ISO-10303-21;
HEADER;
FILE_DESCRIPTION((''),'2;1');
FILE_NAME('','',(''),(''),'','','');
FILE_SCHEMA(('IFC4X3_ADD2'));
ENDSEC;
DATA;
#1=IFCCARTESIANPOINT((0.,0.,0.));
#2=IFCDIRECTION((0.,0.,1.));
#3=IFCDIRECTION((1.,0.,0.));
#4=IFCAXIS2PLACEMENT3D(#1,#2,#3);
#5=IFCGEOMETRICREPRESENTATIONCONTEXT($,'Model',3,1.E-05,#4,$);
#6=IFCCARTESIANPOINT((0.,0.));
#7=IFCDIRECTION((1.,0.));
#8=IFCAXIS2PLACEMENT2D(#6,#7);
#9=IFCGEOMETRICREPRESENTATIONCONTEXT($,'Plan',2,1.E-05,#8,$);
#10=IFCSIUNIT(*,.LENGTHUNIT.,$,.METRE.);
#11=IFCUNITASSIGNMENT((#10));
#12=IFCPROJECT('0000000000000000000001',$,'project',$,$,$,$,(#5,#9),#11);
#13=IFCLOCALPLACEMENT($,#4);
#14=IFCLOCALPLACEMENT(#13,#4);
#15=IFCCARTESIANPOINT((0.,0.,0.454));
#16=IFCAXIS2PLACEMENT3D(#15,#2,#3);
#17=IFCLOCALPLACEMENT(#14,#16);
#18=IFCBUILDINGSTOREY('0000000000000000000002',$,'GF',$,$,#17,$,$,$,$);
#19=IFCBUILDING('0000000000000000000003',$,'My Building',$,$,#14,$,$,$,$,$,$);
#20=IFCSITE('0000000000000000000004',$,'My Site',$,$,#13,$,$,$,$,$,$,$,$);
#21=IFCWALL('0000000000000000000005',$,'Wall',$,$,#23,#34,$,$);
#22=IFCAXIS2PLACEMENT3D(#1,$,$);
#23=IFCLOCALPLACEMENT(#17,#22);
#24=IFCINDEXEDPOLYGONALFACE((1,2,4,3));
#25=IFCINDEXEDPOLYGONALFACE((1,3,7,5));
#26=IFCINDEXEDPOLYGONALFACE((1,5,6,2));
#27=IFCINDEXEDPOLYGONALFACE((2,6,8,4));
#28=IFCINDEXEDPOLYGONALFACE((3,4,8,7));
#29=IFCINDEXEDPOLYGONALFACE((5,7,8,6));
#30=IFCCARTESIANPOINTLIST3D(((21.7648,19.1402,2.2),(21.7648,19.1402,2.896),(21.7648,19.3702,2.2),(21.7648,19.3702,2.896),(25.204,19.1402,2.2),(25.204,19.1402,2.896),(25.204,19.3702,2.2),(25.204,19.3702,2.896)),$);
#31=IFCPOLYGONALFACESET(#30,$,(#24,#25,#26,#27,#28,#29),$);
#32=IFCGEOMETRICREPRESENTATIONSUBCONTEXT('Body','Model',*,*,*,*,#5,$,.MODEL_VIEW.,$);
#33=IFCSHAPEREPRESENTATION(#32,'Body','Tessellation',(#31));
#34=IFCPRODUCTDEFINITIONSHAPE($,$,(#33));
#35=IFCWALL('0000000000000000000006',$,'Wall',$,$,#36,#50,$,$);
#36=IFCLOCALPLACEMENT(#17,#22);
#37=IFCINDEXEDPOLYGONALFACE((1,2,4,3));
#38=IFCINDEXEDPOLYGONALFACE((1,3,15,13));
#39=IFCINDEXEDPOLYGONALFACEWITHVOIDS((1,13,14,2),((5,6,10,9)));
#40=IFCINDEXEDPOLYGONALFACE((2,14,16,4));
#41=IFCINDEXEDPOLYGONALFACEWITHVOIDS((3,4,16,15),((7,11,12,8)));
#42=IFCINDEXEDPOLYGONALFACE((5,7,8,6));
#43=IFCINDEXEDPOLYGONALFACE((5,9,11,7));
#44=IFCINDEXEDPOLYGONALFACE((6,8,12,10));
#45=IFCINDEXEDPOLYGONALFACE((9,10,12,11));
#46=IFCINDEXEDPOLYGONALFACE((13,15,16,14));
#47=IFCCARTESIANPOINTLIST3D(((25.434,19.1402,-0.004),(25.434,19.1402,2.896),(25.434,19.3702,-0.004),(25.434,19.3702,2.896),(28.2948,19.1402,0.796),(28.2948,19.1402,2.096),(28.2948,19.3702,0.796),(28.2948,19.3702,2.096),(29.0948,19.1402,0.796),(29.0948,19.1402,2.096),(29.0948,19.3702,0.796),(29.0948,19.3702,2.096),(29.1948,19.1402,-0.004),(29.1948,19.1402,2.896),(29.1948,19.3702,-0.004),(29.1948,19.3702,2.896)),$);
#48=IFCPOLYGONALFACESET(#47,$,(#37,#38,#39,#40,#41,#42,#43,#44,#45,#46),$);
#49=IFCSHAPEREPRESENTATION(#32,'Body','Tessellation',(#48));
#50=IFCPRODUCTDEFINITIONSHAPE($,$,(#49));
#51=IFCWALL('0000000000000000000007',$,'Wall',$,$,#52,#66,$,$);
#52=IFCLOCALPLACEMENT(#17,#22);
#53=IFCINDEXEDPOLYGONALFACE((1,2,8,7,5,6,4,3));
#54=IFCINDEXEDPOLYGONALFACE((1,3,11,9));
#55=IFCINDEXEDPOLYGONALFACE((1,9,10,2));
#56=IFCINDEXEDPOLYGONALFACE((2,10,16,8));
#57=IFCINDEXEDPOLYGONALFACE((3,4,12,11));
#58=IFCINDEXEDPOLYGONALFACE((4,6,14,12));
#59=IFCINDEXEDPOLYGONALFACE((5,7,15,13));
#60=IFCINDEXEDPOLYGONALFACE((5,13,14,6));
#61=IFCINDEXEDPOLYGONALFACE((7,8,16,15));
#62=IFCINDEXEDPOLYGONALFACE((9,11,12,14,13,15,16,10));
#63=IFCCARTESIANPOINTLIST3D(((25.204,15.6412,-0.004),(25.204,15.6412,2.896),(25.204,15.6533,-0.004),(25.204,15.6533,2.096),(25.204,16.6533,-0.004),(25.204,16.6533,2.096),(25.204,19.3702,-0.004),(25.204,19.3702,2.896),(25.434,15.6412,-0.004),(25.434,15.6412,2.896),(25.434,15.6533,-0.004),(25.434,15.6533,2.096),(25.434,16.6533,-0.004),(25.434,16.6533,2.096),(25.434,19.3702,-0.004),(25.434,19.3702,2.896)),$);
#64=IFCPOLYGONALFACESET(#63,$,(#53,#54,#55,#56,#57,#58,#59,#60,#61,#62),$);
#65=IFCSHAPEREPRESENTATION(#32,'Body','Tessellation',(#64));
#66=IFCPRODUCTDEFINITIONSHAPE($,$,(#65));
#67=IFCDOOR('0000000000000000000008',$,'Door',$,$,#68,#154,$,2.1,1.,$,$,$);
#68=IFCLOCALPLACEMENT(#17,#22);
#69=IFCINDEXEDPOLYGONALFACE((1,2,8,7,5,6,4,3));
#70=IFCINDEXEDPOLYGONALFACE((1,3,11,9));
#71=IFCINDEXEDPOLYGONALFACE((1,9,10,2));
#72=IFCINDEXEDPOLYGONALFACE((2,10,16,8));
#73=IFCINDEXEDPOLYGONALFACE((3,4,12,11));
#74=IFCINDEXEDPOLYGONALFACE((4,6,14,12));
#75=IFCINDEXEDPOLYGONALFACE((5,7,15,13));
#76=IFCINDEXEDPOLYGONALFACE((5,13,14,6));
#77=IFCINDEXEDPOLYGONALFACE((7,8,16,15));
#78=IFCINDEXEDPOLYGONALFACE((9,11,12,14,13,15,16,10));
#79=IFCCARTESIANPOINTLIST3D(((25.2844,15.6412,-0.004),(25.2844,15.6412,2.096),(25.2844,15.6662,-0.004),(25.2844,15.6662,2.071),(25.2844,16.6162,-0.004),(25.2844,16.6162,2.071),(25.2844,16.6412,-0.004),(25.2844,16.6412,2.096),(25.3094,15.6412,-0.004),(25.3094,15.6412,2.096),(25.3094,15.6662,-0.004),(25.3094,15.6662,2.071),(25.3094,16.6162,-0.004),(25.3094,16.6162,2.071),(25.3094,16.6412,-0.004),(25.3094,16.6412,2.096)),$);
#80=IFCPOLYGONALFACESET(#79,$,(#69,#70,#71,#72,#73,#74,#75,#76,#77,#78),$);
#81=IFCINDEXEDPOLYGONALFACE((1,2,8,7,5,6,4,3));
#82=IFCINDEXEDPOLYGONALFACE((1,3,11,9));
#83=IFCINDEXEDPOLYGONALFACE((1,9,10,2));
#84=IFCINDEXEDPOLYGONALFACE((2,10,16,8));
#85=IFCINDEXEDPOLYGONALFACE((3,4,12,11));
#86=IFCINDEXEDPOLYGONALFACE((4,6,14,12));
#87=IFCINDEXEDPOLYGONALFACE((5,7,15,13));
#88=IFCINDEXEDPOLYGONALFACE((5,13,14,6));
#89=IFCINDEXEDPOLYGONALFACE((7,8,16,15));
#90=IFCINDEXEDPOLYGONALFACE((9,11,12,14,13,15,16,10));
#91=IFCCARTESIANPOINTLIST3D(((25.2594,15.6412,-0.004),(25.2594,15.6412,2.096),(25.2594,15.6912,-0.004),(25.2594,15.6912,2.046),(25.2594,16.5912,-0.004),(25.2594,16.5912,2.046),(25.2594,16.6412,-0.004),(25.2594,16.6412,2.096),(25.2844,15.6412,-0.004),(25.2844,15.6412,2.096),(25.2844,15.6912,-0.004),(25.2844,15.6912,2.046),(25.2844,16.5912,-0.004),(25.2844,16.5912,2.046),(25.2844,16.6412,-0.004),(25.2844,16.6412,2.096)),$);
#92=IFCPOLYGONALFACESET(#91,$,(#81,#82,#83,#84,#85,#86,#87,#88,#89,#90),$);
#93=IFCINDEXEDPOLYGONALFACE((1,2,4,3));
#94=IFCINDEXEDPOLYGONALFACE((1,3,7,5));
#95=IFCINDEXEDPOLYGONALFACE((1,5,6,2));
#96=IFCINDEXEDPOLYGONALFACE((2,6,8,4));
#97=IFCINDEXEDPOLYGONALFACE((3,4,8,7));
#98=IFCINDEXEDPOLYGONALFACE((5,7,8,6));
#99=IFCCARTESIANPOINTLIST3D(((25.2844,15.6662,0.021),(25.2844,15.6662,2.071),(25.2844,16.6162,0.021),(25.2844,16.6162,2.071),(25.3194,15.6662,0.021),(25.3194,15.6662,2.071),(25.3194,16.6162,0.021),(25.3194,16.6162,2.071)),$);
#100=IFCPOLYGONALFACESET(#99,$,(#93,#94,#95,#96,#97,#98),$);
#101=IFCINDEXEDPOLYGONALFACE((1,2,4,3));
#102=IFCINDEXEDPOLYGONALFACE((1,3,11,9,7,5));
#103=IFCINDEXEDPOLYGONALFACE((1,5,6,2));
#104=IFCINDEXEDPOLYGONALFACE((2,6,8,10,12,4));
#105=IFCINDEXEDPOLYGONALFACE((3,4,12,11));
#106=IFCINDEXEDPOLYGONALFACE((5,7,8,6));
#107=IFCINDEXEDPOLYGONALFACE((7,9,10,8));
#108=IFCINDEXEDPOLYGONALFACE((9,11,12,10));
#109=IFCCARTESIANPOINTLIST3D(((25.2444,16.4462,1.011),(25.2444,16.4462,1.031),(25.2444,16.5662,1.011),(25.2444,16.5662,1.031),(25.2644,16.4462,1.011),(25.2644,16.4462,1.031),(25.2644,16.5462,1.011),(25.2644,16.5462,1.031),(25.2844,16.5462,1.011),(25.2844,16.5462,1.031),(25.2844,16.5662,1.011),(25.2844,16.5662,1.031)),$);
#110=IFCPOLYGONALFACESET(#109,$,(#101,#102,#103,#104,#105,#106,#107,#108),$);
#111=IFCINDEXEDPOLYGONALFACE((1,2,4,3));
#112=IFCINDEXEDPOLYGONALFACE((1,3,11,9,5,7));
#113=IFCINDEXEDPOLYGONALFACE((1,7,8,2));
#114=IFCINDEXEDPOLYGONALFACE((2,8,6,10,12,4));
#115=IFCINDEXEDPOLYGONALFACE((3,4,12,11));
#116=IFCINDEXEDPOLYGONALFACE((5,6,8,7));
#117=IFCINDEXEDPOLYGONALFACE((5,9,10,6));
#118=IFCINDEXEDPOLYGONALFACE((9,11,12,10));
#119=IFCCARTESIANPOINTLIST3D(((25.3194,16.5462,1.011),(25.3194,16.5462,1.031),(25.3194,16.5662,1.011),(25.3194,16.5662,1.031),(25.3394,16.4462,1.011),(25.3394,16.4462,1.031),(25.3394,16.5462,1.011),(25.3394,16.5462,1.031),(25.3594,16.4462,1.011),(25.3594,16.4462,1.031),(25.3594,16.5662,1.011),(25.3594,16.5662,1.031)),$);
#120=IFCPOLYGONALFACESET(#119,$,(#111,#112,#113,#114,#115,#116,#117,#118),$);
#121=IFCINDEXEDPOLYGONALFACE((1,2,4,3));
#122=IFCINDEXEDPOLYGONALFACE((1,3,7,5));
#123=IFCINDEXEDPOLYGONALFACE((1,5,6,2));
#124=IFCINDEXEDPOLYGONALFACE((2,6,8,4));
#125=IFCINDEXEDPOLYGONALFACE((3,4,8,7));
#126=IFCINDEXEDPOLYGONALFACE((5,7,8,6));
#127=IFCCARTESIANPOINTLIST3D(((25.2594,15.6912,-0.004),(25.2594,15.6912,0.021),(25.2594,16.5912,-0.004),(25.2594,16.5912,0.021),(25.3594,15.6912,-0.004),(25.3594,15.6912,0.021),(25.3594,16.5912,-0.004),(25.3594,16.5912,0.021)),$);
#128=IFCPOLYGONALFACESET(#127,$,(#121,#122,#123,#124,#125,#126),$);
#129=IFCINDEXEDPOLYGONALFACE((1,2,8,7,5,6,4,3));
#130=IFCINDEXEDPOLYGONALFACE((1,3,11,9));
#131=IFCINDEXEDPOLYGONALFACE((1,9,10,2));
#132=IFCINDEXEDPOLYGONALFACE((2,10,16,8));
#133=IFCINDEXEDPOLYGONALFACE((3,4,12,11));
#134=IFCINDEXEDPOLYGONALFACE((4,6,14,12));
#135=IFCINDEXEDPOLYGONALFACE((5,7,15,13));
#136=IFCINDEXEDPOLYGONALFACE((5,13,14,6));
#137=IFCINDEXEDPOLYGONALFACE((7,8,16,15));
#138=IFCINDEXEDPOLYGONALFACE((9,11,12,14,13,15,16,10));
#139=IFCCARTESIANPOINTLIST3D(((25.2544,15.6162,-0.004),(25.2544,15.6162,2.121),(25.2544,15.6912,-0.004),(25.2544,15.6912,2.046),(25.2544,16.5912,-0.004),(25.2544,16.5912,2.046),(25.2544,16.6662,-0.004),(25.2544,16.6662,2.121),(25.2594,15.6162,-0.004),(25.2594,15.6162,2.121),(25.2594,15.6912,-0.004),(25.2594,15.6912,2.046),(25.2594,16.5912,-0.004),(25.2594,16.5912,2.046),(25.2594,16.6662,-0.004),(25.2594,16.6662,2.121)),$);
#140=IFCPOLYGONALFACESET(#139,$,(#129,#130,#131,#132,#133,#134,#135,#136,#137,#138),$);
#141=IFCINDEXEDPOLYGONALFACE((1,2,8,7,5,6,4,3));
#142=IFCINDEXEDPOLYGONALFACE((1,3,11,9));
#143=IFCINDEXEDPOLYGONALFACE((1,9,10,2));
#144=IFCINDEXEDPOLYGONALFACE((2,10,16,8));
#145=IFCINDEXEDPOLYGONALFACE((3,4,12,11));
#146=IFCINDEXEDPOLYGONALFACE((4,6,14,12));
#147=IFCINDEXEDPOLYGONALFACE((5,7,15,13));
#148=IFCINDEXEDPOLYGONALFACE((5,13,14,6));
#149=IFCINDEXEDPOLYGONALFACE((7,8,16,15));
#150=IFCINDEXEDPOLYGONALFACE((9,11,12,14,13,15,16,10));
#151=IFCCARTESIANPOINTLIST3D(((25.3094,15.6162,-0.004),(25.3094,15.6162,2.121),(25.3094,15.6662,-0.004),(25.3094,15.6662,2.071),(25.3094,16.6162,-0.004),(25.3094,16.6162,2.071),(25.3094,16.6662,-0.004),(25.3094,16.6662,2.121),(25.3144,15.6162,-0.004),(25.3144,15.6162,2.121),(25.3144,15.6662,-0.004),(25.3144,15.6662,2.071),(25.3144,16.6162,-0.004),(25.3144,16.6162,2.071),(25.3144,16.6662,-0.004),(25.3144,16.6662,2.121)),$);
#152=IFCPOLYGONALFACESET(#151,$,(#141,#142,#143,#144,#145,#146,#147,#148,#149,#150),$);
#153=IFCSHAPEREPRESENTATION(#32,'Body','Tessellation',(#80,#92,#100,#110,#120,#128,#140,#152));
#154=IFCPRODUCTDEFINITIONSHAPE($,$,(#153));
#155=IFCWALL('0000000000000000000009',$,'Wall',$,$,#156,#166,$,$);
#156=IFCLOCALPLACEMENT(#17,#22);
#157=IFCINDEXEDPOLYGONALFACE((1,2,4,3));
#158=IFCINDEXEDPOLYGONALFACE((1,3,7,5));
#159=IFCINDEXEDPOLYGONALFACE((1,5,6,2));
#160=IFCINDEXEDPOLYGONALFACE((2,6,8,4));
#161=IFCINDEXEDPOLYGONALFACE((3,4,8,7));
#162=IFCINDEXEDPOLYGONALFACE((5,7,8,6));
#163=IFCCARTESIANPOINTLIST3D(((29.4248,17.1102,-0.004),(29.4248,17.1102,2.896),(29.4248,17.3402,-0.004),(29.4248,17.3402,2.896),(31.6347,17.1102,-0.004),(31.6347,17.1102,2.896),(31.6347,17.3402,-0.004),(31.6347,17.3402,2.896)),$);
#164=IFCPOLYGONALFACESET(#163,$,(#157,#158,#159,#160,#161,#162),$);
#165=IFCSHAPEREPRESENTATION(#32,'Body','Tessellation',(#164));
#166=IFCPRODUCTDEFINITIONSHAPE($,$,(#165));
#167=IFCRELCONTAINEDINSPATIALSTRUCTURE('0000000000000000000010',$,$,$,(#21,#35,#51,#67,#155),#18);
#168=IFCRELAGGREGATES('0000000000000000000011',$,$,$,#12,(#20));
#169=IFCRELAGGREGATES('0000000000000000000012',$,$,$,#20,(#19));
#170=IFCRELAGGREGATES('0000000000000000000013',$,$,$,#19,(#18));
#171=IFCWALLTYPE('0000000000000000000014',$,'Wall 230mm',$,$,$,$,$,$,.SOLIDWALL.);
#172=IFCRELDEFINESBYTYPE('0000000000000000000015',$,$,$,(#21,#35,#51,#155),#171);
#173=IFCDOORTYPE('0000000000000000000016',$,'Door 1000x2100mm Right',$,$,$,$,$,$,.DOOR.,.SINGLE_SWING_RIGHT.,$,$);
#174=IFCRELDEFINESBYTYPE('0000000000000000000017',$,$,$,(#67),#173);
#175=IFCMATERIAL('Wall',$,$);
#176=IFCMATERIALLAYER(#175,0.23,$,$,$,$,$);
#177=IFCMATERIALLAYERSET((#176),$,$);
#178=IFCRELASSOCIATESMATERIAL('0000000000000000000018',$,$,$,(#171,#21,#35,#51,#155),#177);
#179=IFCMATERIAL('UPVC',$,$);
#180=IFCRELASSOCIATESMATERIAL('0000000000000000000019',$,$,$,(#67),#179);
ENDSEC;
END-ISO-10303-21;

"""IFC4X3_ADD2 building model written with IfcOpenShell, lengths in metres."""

from ifc_helpers import new_model, entity, si_unit, frame, origin_with_axes, origin_2d_with_axis, place, context, subcontext, project, spatial, line, indexed_curve, outline, extrude, clip, halfspace, shape, source, transform, mapped, material, layer, layer_set, layer_usage, type_object, type_shapes, element, fill, save


model = new_model("IFC4X3_ADD2")

# Units and contexts
model_context = context("Model", 3, precision=1e-05, world=origin_with_axes())
plan_context = context("Plan", 2, precision=1e-05, world=origin_2d_with_axis())
body_context_1 = subcontext(model_context, "Body", "Model", "MODEL_VIEW")
body_context_2 = subcontext(plan_context, "Body", "Plan", "PLAN_VIEW")
ifc_project = project(units=[si_unit("LENGTHUNIT", "METRE")], contexts=[model_context, plan_context])

# Site, building, storey
site_placement = place(None, origin_with_axes())
site = spatial("IfcSite", under=ifc_project, at=site_placement, Name="My Site")
building_placement = place(site_placement, origin_with_axes())
building = spatial("IfcBuilding", under=site, at=building_placement, Name="My Building")
storey_placement = place(building_placement, frame((0.0, 0.0, 0.454), z_axis=(0.0, 0.0, 1.0), x_axis=(1.0, 0.0, 0.0)))
storey = spatial("IfcBuildingStorey", under=building, at=storey_placement, Name="GF")

# Shared definitions
ifc_material_1 = material(Name="Wall")

# Shared definitions
ifc_material_2 = material(Name="UPVC")

# Shared definitions
ifc_layer_1 = layer(ifc_material_1, 0.23)
ifc_layer_set_1 = layer_set([ifc_layer_1])
wall_type_1 = type_object("IfcWallType", Name="Wall 230mm", PredefinedType="SOLIDWALL", material=ifc_layer_set_1)

# Shared definitions
shared_shape_1 = source(origin_with_axes(), body_context_1, "Body", "SweptSolid", [
    extrude(outline(indexed_curve([(0.0, 0.0), (0.8, 0.0), (0.8, 1.3), (0.0, 1.3)], segments=[line(1, 2, 3, 4, 1)])), frame((-0.4, -0.6, 0.0), z_axis=(0.0, -1.0, 0.0), x_axis=(1.0, 0.0, 0.0)), (0.0, 0.0, -1.0), 1.2),
])

# Wall
ifc_layer_usage_1 = layer_usage(ifc_layer_set_1, "AXIS2", "POSITIVE", 0.0)
wall_1_placement = place(storey_placement, frame((25.204, 19.3702, 2.2), z_axis=(0.0, 0.0, 1.0), x_axis=(-1.0, 0.0, 0.0)))
element("IfcWall", 1, at=wall_1_placement, inside=storey, type_object=wall_type_1, material=ifc_layer_usage_1, Name="Wall", context=body_context_1, shape_type="Clipping", body=[
    clip(clip(extrude(outline(indexed_curve([(0.0, 0.0), (0.0, 0.23), (3.4392, 0.23), (3.4392, 0.0), (0.0, 0.0)], self_intersect=False)), origin_with_axes(), (0.0, 0.0, 1.0), 6.25), halfspace(frame((0.0, 0.0, 3.596), z_axis=(0.0, 0.0, 1.0), x_axis=(-1.0, 0.0, 0.0)), False)), halfspace(frame((0.0, 0.0, 0.696), z_axis=(0.0, 0.0, 1.0), x_axis=(-1.0, 0.0, 0.0)), False)),
])

# Wall, opening
ifc_layer_usage_2 = layer_usage(ifc_layer_set_1, "AXIS2", "POSITIVE", 0.0)
wall_2_placement = place(storey_placement, frame((29.1948, 19.3702, -0.004), z_axis=(0.0, 0.0, 1.0), x_axis=(-1.0, 0.0, 0.0)))
wall_2 = element("IfcWall", 2, at=wall_2_placement, inside=storey, type_object=wall_type_1, material=ifc_layer_usage_2, Name="Wall", context=body_context_1, shape_type="SweptSolid", body=[
    extrude(outline(indexed_curve([(0.0, 0.0), (0.0, 0.23), (3.7608, 0.23), (3.7608, 0.0), (0.0, 0.0)], self_intersect=False)), origin_with_axes(), (0.0, 0.0, 1.0), 2.9),
])
opening_1_placement = place(wall_2_placement, frame((0.5, 0.16, 0.8), z_axis=(0.0, 0.0, 1.0), x_axis=(1.0, 0.0, 0.0)))
element("IfcOpeningElement", 3, at=opening_1_placement, cuts=wall_2, PredefinedType="OPENING", context=body_context_1, shape_type="MappedRepresentation", body=[
    mapped(shared_shape_1, transform((0.0, 0.0, 0.0), x_axis=(1.0, 0.0, 0.0), y_axis=(0.0, 1.0, 0.0), z_axis=(0.0, 0.0, 1.0), scale=1.0)),
])

# Wall, opening, door
ifc_layer_usage_3 = layer_usage(ifc_layer_set_1, "AXIS2", "POSITIVE", 0.0)
wall_3_placement = place(storey_placement, frame((25.434, 15.6412, -0.004), z_axis=(0.0, 0.0, 1.0), x_axis=(0.000001, 1.0, 0.0)))
wall_3 = element("IfcWall", 4, at=wall_3_placement, inside=storey, type_object=wall_type_1, material=ifc_layer_usage_3, Name="Wall", context=body_context_1, shape_type="SweptSolid", body=[
    extrude(outline(indexed_curve([(0.0, 0.0), (0.0, 0.23), (3.729, 0.23), (3.729, 0.0), (0.0, 0.0)], self_intersect=False)), origin_with_axes(), (0.0, 0.0, 1.0), 2.9),
])
shared_shape_2 = source(origin_with_axes(), body_context_1, "Body", "SweptSolid", [
    extrude(outline(indexed_curve([(0.0, 0.0), (1.0, 0.0), (1.0, 2.1), (0.0, 2.1)], segments=[line(1, 2, 3, 4, 1)])), frame((0.0, -0.6, 0.0), z_axis=(0.0, -1.0, 0.0), x_axis=(1.0, 0.0, 0.0)), (0.0, 0.0, -1.0), 1.2),
])
opening_2_placement = place(wall_3_placement, frame((0.012, 0.0, 0.0), z_axis=(0.0, 0.0, 1.0), x_axis=(1.0, 0.0, 0.0)))
opening_2 = element("IfcOpeningElement", 5, at=opening_2_placement, cuts=wall_3, PredefinedType="OPENING", context=body_context_1, shape_type="MappedRepresentation", body=[
    mapped(shared_shape_2, transform((0.0, 0.0, 0.0), x_axis=(1.0, 0.0, 0.0), y_axis=(0.0, 1.0, 0.0), z_axis=(0.0, 0.0, 1.0), scale=1.0)),
])
door_type_1 = type_object("IfcDoorType", Name="Door 1000x2100mm Right", OperationType="SINGLE_SWING_RIGHT", PredefinedType="DOOR")
shared_shape_3 = source(origin_with_axes(), body_context_1, "Body", "SweptSolid", [
    extrude(outline(indexed_curve([(0.0, 0.0), (0.0, 2.1), (1.0, 2.1), (1.0, 0.0), (0.975, 0.0), (0.975, 2.075), (0.025, 2.075), (0.025, 0.0)], segments=[line(1, 2, 3, 4, 5, 6, 7, 8, 1)])), frame((0.0, 0.025, 0.0), z_axis=(0.0, -1.0, 0.0), x_axis=(1.0, 0.0, 0.0)), (0.0, 0.0, -1.0), 0.025),
    extrude(outline(indexed_curve([(0.0, 0.0), (0.0, 2.1), (1.0, 2.1), (1.0, 0.0), (0.95, 0.0), (0.95, 2.05), (0.05, 2.05), (0.05, 0.0)], segments=[line(1, 2, 3, 4, 5, 6, 7, 8, 1)])), frame((0.0, 0.0, 0.0), z_axis=(0.0, -1.0, 0.0), x_axis=(1.0, 0.0, 0.0)), (0.0, 0.0, -1.0), 0.025),
    extrude(outline(indexed_curve([(0.0, 0.0), (0.95, 0.0), (0.95, 0.035), (0.0, 0.035)], segments=[line(1, 2, 3, 4, 1)])), frame((0.025, 0.025, 0.025), z_axis=(0.0, 0.0, 1.0), x_axis=(1.0, 0.0, 0.0)), (0.0, 0.0, 1.0), 2.05),
    extrude(outline(indexed_curve([(0.0, 0.0), (0.0, -0.04), (0.12, -0.04), (0.12, -0.02), (0.02, -0.02), (0.02, 0.0)], segments=[line(1, 2, 3, 4, 5, 6, 1)])), frame((0.075, 0.025, 1.015), z_axis=(0.0, 0.0, 1.0), x_axis=(1.0, 0.0, 0.0)), (0.0, 0.0, 1.0), 0.02),
    extrude(outline(indexed_curve([(0.0, 0.0), (0.0, 0.04), (0.12, 0.04), (0.12, 0.02), (0.02, 0.02), (0.02, 0.0)], segments=[line(1, 2, 3, 4, 5, 6, 1)])), frame((0.075, 0.06, 1.015), z_axis=(0.0, 0.0, 1.0), x_axis=(1.0, 0.0, 0.0)), (0.0, 0.0, 1.0), 0.02),
    extrude(outline(indexed_curve([(0.0, 0.0), (0.9, 0.0), (0.9, 0.1), (0.0, 0.1)], segments=[line(1, 2, 3, 4, 1)])), frame((0.05, 0.0, 0.0), z_axis=(0.0, 0.0, 1.0), x_axis=(1.0, 0.0, 0.0)), (0.0, 0.0, 1.0), 0.025),
    extrude(outline(indexed_curve([(0.0, 0.0), (0.0, 2.125), (1.05, 2.125), (1.05, 0.0), (0.975, 0.0), (0.975, 2.05), (0.075, 2.05), (0.075, 0.0)], segments=[line(1, 2, 3, 4, 5, 6, 7, 8, 1)])), frame((-0.025, -0.005, 0.0), z_axis=(0.0, -1.0, 0.0), x_axis=(1.0, 0.0, 0.0)), (0.0, 0.0, -1.0), 0.005),
    extrude(outline(indexed_curve([(0.0, 0.0), (0.0, 2.125), (1.05, 2.125), (1.05, 0.0), (1.0, 0.0), (1.0, 2.075), (0.05, 2.075), (0.05, 0.0)], segments=[line(1, 2, 3, 4, 5, 6, 7, 8, 1)])), frame((-0.025, 0.05, 0.0), z_axis=(0.0, -1.0, 0.0), x_axis=(1.0, 0.0, 0.0)), (0.0, 0.0, -1.0), 0.005),
])
shared_shape_4 = source(origin_with_axes(), body_context_2, "Body", "Curve2D", [
    entity("IfcIndexedPolyCurve", entity("IfcCartesianPointList2D", [[0.0, 0.0], [0.0, 0.05], [0.025, 0.05], [0.025, 0.025], [0.05, 0.025], [0.05, 0.0]]), [entity("IfcLineIndex", [1, 2, 3, 4, 5, 6, 1])]),
    entity("IfcIndexedPolyCurve", entity("IfcCartesianPointList2D", [[1.0, 0.0], [1.0, 0.05], [0.975, 0.05], [0.975, 0.025], [0.95, 0.025], [0.95, 0.0]]), [entity("IfcLineIndex", [1, 2, 3, 4, 5, 6, 1])]),
    entity("IfcTrimmedCurve", entity("IfcEllipse", entity("IfcAxis2Placement2D", entity("IfcCartesianPoint", [0.94, 0.05]), entity("IfcDirection", [1.0, 0.0])), 0.915, 0.95), [entity("IfcCartesianPoint", [0.94, 1.0])], [entity("IfcCartesianPoint", [0.025, 0.05])], True, "CARTESIAN"),
    entity("IfcIndexedPolyCurve", entity("IfcCartesianPointList2D", [[0.975, 0.05], [0.94, 0.05], [0.94, 1.0], [0.975, 1.0]]), [entity("IfcLineIndex", [1, 2, 3, 4, 1])]),
])
type_shapes(door_type_1, [shared_shape_3, shared_shape_4])
door_1_placement = place(opening_2_placement, frame((0.988, 0.1746, 0.0), z_axis=(0.0, 0.0, 1.0), x_axis=(-1.0, 0.0, 0.0)))
door_1 = element("IfcDoor", 6, at=door_1_placement, inside=storey, type_object=door_type_1, material=ifc_material_2, Name="Door", OverallHeight=2.1, OverallWidth=1.0, shapes=[
    shape(body_context_1, "Body", "MappedRepresentation", [mapped(shared_shape_3, transform((0.0, 0.0, 0.0), x_axis=(1.0, 0.0, 0.0), y_axis=(0.0, 1.0, 0.0), z_axis=(0.0, 0.0, 1.0), scale=1.0))]),
    shape(body_context_2, "Body", "MappedRepresentation", [mapped(shared_shape_4, transform((0.0, 0.0, 0.0), x_axis=(1.0, 0.0, 0.0), y_axis=(0.0, 1.0, 0.0), z_axis=(0.0, 0.0, 1.0), scale=1.0))]),
])
fill(opening_2, door_1)

# Wall
ifc_layer_usage_4 = layer_usage(ifc_layer_set_1, "AXIS2", "POSITIVE", 0.0)
wall_4_placement = place(storey_placement, frame((31.6347, 17.3402, -0.004), z_axis=(0.0, 0.0, 1.0), x_axis=(-1.0, 0.0, 0.0)))
element("IfcWall", 7, at=wall_4_placement, inside=storey, type_object=wall_type_1, material=ifc_layer_usage_4, Name="Wall", context=body_context_1, shape_type="SweptSolid", body=[
    extrude(outline(indexed_curve([(0.0, 0.0), (0.0, 0.23), (2.21, 0.23), (2.21, 0.0), (0.0, 0.0)], self_intersect=False)), origin_with_axes(), (0.0, 0.0, 1.0), 2.9),
])

save(model, "model.ifc")
